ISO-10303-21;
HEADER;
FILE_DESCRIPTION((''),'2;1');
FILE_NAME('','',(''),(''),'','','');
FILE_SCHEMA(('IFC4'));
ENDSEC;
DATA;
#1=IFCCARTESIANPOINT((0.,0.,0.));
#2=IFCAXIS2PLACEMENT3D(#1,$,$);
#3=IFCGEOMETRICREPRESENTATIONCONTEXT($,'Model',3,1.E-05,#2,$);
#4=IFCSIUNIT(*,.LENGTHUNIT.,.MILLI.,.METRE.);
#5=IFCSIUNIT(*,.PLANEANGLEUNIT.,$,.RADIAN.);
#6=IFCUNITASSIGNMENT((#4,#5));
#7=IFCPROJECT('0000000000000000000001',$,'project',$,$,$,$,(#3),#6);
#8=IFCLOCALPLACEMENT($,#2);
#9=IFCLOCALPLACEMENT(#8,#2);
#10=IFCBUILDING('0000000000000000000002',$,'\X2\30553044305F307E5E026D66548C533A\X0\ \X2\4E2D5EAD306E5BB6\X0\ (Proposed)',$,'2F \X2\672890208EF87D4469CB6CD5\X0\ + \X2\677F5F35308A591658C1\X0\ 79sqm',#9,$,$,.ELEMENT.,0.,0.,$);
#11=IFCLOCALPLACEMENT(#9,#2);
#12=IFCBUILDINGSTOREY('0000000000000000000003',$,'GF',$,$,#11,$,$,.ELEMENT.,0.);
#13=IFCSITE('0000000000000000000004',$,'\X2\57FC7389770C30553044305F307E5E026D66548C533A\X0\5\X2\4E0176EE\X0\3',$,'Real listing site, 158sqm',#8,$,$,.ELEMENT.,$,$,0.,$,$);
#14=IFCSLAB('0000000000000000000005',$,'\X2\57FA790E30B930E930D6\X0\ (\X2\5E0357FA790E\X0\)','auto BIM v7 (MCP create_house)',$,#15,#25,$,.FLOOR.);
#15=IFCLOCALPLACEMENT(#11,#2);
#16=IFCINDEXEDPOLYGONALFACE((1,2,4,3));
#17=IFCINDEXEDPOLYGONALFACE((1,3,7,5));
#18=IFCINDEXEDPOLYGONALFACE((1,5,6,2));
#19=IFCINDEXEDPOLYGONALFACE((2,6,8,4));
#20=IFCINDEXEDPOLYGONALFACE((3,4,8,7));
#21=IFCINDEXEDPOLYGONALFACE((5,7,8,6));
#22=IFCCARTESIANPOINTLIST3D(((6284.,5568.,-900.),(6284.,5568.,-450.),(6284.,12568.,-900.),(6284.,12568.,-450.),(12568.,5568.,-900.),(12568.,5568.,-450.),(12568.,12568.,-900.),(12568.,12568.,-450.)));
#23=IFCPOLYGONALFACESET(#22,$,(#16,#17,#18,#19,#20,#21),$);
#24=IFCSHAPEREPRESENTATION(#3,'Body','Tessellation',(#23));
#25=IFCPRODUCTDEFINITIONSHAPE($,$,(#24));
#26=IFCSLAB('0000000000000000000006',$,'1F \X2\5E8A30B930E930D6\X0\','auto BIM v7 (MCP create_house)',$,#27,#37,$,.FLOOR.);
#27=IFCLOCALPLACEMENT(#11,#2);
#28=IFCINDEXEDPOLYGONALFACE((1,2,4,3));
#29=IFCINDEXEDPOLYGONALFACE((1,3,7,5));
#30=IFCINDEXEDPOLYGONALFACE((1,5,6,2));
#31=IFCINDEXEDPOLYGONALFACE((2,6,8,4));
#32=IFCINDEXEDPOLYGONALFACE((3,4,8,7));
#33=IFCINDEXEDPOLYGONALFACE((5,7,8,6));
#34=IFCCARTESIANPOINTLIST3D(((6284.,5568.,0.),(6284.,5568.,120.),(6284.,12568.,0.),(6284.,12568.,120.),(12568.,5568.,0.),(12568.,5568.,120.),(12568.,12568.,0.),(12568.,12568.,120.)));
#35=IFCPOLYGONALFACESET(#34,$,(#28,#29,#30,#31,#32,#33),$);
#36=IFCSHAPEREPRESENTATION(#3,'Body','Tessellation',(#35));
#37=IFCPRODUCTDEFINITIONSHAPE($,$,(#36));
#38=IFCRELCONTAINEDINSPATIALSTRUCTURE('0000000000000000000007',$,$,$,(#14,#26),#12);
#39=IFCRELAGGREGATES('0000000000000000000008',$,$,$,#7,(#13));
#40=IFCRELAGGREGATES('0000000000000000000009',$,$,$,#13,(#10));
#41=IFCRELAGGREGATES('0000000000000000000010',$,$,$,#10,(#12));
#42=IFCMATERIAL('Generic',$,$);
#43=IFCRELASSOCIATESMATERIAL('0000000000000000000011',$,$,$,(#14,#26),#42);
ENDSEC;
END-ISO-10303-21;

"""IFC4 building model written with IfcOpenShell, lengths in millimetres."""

from ifc_helpers import new_model, si_unit, frame, frame_2d, origin, place, context, project, spatial, rectangle, extrude, material, element, save


model = new_model("IFC4")

# Units and contexts
model_context = context("Model", 3, precision=1e-05, world=origin())
ifc_project = project(units=[si_unit("LENGTHUNIT", "METRE", prefix="MILLI"), si_unit("PLANEANGLEUNIT", "RADIAN")], contexts=[model_context])

# Site, building, storey
site_placement = place(None, origin())
site = spatial("IfcSite", under=ifc_project, at=site_placement, Name="埼玉県さいたま市浦和区5丁目3", ObjectType="Real listing site, 158sqm", CompositionType="ELEMENT", RefElevation=0.0)
building_placement = place(site_placement, origin())
building = spatial("IfcBuilding", under=site, at=building_placement, Name="さいたま市浦和区 中庭の家 (Proposed)", ObjectType="2F 木造軸組構法 + 板張り外壁 79sqm", CompositionType="ELEMENT", ElevationOfRefHeight=0.0, ElevationOfTerrain=0.0)
storey_placement = place(building_placement, origin())
storey = spatial("IfcBuildingStorey", under=building, at=storey_placement, Name="GF", CompositionType="ELEMENT", Elevation=0.0)

# Slabs
ifc_material = material(Name="Generic")
slab_1_placement = place(storey_placement, frame((3142.0, 2784.0, -450.0)))
element("IfcSlab", 1, at=slab_1_placement, inside=storey, material=ifc_material, Name="基礎スラブ (布基礎)", Description="auto BIM v7 (MCP create_house)", PredefinedType="FLOOR", context=model_context, shape_type="SweptSolid", body=[
    extrude(rectangle(XDim=6284.0, YDim=7000.0, at=frame_2d((3142.0, 3500.0))), frame((3142.0, 2784.0, -450.0)), (0.0, 0.0, 1.0), 450.0),
])
slab_2_placement = place(storey_placement, frame((3142.0, 2784.0, 0.0)))
element("IfcSlab", 2, at=slab_2_placement, inside=storey, material=ifc_material, Name="1F 床スラブ", Description="auto BIM v7 (MCP create_house)", PredefinedType="FLOOR", context=model_context, shape_type="SweptSolid", body=[
    extrude(rectangle(XDim=6284.0, YDim=7000.0, at=frame_2d((3142.0, 3500.0))), frame((3142.0, 2784.0, 0.0)), (0.0, 0.0, 1.0), 120.0),
])

save(model, "model.ifc")
